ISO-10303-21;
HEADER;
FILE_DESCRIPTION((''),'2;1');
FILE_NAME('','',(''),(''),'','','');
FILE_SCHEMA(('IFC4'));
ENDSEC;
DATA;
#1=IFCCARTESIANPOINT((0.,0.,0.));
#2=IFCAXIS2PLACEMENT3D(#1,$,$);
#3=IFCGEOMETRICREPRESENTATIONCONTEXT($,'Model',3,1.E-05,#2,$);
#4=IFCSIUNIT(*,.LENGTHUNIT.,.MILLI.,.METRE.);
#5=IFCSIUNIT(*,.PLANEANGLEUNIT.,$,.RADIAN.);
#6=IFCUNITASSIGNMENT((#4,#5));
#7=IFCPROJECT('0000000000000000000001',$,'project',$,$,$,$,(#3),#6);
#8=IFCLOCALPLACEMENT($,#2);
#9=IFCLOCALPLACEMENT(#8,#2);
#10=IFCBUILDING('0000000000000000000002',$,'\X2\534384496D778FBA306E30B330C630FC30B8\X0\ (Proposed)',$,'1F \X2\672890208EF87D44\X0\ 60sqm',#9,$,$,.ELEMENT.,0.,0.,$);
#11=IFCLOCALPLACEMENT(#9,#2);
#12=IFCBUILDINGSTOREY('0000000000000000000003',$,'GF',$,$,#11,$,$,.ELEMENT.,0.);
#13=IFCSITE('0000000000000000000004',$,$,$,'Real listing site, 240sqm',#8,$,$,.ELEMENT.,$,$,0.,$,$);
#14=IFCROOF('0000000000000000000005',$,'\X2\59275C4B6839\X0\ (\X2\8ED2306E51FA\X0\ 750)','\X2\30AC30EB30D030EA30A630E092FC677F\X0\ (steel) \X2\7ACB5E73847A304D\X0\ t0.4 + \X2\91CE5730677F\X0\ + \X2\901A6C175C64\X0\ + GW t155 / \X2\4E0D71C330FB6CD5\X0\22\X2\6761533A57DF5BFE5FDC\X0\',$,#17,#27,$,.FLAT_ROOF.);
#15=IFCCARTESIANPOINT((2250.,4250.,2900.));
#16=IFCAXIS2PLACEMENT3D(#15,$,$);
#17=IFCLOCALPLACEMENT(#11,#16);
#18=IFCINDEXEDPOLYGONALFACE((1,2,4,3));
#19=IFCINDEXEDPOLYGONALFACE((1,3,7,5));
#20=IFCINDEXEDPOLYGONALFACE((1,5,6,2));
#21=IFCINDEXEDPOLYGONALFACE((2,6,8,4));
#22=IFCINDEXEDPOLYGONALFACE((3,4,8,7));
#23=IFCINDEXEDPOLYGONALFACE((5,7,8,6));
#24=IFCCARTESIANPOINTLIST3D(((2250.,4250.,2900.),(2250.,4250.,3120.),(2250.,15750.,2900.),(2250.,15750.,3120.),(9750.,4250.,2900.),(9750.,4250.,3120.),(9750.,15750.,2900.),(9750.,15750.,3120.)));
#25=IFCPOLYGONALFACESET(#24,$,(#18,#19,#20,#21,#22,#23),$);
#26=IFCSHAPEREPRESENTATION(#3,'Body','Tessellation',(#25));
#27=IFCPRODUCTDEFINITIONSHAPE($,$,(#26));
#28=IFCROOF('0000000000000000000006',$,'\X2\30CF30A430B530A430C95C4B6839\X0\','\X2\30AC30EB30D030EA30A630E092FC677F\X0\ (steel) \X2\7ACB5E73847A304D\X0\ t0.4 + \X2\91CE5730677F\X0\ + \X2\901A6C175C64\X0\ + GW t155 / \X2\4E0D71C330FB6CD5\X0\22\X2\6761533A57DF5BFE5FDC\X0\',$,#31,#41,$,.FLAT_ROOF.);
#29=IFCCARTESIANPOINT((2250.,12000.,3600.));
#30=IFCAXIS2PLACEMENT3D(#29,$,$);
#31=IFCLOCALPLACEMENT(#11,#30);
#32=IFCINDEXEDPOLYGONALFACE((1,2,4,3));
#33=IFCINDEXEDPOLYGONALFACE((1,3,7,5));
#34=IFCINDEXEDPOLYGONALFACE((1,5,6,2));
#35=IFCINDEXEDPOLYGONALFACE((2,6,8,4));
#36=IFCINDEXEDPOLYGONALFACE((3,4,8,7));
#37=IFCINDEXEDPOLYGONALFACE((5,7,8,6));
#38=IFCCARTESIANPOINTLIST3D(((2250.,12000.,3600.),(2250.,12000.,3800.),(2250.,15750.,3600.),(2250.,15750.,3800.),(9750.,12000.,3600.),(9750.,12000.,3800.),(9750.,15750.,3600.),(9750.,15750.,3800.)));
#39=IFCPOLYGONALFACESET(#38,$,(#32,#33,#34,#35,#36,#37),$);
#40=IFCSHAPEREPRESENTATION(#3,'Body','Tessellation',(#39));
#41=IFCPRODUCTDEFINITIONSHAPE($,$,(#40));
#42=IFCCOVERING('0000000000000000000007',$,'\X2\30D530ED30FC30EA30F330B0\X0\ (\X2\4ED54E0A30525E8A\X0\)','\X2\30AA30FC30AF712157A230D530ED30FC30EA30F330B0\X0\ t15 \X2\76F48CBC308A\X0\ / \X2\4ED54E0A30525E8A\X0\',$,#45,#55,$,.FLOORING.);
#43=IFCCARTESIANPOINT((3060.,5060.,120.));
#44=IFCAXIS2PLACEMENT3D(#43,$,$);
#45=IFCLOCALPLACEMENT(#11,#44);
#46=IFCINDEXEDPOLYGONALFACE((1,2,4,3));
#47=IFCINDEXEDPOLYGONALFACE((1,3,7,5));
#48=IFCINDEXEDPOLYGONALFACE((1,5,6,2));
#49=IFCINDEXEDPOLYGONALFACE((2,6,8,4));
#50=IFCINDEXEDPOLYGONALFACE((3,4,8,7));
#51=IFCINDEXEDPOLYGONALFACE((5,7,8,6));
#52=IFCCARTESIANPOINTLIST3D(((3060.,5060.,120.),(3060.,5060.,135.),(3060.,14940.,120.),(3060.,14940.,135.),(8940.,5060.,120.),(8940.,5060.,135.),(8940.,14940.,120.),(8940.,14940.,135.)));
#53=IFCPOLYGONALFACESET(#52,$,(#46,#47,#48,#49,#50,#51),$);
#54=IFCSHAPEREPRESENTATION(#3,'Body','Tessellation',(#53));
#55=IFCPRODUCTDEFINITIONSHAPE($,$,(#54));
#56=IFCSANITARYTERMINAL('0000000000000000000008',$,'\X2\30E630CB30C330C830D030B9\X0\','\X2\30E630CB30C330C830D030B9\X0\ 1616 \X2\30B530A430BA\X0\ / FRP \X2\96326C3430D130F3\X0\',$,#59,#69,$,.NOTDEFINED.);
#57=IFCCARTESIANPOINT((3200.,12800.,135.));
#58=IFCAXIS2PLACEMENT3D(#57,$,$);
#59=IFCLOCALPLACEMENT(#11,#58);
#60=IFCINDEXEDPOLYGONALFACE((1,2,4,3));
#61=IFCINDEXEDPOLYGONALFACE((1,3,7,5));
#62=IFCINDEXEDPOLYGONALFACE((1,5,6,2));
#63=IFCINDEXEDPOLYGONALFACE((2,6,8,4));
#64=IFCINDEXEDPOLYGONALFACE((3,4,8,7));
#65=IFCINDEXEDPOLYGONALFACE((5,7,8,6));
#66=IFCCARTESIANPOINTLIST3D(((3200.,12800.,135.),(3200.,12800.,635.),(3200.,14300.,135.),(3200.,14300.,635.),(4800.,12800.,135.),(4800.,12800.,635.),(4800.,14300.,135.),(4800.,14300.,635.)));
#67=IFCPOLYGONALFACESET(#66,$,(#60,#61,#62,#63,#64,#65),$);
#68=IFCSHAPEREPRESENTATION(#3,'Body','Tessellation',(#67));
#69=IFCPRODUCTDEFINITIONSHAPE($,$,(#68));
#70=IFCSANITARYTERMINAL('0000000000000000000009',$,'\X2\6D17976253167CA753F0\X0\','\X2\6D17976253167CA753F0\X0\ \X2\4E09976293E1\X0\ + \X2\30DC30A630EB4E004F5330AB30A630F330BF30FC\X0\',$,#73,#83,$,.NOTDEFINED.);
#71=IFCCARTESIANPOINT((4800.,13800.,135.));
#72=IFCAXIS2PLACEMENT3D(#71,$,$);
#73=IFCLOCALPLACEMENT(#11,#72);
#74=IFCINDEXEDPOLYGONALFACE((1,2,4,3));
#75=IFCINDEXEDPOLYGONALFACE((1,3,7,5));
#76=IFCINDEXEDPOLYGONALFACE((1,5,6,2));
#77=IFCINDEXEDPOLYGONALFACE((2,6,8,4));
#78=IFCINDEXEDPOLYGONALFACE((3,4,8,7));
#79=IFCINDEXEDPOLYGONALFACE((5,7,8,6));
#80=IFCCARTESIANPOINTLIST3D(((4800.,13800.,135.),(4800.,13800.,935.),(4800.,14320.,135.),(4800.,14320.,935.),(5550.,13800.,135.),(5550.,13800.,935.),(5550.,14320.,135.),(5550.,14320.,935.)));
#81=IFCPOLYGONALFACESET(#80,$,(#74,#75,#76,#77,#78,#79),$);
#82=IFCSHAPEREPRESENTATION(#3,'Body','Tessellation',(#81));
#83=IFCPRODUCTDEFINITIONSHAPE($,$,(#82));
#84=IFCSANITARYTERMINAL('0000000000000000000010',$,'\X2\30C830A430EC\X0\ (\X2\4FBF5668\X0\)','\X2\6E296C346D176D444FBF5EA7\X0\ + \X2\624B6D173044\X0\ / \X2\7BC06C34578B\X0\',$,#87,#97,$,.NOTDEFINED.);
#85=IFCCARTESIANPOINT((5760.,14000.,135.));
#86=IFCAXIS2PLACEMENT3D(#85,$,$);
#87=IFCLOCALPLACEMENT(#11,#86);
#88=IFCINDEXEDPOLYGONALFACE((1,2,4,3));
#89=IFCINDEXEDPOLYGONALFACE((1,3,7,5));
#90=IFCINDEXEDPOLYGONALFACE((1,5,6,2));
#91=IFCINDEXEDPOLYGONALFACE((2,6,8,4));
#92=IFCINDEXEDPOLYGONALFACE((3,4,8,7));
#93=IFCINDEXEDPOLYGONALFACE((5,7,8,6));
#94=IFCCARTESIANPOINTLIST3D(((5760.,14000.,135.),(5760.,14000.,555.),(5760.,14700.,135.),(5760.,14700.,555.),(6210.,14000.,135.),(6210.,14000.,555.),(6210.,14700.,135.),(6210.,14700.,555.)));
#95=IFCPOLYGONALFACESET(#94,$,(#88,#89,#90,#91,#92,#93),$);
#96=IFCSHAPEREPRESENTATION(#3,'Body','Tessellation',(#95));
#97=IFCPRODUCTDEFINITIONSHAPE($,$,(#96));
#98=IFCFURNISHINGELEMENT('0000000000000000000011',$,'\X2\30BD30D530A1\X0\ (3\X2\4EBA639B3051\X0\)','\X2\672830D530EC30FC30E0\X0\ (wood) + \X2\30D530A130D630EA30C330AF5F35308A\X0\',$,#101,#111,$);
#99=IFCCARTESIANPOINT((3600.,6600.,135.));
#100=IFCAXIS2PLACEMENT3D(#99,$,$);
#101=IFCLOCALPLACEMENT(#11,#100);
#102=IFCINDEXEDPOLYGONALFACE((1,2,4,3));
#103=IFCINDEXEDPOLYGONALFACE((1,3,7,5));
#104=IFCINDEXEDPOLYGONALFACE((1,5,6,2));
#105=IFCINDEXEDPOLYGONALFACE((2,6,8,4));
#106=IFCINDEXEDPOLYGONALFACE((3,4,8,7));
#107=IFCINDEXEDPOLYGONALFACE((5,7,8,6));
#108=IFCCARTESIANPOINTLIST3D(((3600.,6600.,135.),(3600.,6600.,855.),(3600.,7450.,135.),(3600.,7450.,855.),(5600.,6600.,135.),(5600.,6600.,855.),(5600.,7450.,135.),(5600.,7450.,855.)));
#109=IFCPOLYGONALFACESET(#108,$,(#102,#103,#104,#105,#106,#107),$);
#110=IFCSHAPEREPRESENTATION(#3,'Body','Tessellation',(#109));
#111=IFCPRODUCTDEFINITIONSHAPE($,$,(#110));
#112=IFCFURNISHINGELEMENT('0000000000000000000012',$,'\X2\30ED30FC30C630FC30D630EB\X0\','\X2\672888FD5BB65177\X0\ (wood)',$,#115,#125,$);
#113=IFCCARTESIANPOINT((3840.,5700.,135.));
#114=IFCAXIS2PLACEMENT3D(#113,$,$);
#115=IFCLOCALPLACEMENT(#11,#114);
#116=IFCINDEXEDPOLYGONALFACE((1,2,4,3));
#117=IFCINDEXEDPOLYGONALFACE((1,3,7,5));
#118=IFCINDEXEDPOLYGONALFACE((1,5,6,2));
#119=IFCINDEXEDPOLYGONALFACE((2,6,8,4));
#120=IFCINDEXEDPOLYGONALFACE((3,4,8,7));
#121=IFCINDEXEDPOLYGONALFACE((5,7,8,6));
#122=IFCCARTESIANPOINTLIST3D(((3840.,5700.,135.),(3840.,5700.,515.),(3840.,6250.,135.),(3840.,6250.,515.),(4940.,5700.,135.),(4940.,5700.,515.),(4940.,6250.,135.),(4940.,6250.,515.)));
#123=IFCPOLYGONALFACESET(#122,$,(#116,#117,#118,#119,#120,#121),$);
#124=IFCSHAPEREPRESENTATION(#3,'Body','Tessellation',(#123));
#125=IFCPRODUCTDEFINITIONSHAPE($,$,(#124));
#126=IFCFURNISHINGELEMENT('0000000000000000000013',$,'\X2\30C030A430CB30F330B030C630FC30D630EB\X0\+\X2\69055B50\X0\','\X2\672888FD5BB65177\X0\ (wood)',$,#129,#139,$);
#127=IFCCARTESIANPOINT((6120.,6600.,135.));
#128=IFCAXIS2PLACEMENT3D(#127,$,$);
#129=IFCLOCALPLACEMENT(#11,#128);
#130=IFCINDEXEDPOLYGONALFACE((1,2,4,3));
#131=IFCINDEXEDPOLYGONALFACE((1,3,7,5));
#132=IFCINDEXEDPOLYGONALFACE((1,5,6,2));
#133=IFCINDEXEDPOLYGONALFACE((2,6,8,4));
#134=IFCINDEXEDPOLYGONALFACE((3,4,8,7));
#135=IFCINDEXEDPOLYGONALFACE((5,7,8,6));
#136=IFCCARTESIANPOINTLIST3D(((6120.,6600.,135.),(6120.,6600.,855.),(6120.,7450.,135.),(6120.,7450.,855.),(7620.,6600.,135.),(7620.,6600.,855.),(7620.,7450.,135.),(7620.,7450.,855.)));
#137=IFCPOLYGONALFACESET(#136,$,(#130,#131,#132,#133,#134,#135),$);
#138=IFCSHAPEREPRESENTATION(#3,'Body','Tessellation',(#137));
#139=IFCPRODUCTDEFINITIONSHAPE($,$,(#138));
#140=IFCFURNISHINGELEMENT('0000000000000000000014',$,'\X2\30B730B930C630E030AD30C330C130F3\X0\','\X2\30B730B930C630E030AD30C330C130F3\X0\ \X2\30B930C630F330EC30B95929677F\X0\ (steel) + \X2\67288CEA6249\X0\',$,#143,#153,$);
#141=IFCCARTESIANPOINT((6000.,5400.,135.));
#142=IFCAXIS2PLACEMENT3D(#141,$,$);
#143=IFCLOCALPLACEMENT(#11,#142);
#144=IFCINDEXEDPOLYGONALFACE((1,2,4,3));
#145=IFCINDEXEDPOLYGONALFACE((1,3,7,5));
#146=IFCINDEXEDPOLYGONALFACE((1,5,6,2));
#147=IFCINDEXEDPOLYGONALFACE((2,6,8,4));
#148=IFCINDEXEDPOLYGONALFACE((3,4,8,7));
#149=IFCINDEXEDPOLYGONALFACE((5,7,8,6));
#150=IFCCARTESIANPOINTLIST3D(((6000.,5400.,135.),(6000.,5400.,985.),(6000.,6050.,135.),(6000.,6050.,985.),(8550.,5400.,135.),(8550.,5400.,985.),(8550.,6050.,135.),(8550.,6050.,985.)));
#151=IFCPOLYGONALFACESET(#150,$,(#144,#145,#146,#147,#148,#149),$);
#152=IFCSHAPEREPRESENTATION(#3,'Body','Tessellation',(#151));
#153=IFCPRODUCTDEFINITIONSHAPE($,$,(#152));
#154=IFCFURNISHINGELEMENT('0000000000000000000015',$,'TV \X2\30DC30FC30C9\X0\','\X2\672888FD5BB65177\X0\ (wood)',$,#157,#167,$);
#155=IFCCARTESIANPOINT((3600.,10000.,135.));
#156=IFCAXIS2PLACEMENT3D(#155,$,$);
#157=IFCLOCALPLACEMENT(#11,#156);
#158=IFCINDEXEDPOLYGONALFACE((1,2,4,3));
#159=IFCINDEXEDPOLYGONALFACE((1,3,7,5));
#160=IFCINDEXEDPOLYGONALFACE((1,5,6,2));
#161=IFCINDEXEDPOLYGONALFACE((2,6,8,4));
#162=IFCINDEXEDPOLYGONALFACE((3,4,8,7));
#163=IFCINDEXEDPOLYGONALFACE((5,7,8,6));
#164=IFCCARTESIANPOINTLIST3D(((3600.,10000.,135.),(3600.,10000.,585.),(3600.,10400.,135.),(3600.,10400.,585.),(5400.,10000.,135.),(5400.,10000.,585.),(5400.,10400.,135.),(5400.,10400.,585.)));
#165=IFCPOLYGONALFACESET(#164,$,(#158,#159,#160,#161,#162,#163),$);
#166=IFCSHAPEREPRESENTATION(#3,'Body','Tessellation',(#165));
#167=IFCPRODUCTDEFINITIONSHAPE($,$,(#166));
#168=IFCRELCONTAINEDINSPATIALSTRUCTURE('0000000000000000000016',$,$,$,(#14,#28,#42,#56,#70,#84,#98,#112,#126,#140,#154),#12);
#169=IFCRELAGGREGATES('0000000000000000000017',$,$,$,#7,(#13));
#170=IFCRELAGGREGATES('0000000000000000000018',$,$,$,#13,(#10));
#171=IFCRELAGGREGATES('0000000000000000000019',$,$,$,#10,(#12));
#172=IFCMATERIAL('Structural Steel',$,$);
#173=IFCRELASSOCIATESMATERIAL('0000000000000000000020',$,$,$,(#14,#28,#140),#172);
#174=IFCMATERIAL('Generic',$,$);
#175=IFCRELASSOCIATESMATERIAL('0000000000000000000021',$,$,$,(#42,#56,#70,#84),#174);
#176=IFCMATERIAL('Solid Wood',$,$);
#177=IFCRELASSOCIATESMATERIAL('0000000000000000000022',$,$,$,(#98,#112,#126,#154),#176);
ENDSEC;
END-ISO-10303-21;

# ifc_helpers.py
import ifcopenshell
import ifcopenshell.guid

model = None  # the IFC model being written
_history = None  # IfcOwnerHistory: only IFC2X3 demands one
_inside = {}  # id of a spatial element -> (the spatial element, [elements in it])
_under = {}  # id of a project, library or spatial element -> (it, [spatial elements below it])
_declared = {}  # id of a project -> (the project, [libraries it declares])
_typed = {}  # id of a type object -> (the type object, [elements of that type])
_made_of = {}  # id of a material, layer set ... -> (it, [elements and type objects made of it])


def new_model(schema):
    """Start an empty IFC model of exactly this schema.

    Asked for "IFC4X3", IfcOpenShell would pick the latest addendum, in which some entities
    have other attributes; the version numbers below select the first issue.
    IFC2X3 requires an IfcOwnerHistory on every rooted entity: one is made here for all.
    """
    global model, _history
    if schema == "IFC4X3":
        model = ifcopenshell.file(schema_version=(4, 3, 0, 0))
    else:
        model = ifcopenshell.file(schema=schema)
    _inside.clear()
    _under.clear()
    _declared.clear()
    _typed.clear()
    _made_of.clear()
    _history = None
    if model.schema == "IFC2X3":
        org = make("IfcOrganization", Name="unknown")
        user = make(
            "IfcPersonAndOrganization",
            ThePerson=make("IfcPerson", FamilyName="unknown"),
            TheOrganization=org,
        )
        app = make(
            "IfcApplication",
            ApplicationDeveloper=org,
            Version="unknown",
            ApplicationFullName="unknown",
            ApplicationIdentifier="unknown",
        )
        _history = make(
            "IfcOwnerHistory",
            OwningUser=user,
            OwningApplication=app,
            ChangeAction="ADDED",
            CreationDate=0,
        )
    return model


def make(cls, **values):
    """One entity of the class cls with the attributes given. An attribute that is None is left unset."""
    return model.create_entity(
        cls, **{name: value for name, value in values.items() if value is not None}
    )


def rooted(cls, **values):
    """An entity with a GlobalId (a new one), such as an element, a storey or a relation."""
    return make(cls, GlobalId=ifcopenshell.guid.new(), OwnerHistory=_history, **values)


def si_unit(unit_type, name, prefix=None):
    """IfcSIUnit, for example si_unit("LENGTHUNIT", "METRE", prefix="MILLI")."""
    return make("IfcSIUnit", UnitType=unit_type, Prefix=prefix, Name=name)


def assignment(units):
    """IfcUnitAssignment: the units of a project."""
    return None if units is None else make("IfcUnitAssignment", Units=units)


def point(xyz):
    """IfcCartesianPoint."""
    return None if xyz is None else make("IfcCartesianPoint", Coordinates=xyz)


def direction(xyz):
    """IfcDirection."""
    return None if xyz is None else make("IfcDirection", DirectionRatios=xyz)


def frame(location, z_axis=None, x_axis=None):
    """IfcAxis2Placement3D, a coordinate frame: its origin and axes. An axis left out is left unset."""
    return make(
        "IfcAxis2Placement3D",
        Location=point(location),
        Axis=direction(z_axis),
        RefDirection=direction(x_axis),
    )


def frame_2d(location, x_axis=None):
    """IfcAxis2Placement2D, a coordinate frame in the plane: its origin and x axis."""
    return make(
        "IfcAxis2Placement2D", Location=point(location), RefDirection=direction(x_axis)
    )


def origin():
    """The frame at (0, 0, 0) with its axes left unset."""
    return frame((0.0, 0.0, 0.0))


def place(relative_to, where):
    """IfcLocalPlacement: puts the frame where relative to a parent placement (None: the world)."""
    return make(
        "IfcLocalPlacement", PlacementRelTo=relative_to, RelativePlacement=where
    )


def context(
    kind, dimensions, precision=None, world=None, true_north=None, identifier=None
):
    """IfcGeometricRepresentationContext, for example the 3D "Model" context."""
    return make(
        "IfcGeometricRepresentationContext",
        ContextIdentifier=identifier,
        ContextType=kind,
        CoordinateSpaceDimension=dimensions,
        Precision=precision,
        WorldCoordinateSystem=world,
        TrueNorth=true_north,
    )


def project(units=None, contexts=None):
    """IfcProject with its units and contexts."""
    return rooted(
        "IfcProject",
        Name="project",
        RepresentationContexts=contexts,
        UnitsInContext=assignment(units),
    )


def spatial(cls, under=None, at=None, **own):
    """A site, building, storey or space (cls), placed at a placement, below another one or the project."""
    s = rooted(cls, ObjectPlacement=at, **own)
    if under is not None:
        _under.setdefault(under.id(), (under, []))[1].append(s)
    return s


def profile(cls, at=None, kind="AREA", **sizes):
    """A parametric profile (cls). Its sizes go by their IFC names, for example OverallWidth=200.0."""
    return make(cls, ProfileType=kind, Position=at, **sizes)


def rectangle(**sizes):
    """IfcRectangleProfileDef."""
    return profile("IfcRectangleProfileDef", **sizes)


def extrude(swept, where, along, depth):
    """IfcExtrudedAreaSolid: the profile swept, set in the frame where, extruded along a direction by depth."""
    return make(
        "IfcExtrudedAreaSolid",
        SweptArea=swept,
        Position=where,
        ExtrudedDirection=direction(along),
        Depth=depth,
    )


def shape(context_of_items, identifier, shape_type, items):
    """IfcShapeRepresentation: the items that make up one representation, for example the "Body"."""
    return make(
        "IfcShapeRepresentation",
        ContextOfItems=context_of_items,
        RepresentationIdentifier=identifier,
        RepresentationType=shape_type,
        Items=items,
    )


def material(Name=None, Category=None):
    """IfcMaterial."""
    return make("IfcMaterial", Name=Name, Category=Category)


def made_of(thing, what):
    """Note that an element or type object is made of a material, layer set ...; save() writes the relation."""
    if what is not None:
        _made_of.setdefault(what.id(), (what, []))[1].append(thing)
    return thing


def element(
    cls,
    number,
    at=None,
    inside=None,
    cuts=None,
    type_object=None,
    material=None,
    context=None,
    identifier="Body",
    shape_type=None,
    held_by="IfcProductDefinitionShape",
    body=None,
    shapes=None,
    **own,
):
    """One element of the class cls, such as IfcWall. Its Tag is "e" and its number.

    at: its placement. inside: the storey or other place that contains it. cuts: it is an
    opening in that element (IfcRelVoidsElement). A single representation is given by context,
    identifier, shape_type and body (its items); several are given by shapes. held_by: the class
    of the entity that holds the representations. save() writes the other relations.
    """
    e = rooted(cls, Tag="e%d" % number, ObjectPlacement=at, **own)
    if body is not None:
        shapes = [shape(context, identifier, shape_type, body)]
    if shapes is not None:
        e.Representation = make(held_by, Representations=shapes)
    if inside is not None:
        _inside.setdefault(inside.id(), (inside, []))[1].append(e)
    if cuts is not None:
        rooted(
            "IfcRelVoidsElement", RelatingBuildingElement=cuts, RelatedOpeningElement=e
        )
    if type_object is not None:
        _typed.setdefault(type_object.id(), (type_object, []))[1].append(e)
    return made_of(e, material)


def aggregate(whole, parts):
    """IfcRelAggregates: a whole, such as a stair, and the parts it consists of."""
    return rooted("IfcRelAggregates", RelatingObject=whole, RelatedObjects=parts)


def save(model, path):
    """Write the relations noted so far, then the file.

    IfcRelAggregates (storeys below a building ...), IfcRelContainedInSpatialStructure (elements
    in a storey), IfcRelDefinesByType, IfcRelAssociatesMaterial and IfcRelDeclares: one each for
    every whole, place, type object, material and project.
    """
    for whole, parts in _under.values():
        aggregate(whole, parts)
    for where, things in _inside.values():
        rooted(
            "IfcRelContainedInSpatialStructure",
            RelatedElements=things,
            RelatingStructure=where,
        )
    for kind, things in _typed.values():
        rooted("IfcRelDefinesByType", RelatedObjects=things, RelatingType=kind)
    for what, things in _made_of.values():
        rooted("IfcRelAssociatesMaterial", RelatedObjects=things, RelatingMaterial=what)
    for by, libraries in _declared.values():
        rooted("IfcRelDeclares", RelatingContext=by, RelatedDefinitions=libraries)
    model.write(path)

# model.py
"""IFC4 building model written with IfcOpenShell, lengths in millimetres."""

from ifc_helpers import new_model, si_unit, frame, frame_2d, origin, place, context, project, spatial, rectangle, extrude, material, element, save


model = new_model("IFC4")

# Units and contexts
model_context = context("Model", 3, precision=1e-05, world=origin())
ifc_project = project(units=[si_unit("LENGTHUNIT", "METRE", prefix="MILLI"), si_unit("PLANEANGLEUNIT", "RADIAN")], contexts=[model_context])

# Site, building, storey
site_placement = place(None, origin())
site = spatial("IfcSite", under=ifc_project, at=site_placement, ObjectType="Real listing site, 240sqm", CompositionType="ELEMENT", RefElevation=0.0)
building_placement = place(site_placement, origin())
building = spatial("IfcBuilding", under=site, at=building_placement, Name="千葉海辺のコテージ (Proposed)", ObjectType="1F 木造軸組 60sqm", CompositionType="ELEMENT", ElevationOfRefHeight=0.0, ElevationOfTerrain=0.0)
storey_placement = place(building_placement, origin())
storey = spatial("IfcBuildingStorey", under=building, at=storey_placement, Name="GF", CompositionType="ELEMENT", Elevation=0.0)

# Shared definitions
ifc_material_1 = material(Name="Solid Wood")

# Roofs
ifc_material_2 = material(Name="Structural Steel")
roof_1_placement = place(storey_placement, frame((2250.0, 4250.0, 2900.0)))
element("IfcRoof", 1, at=roof_1_placement, inside=storey, material=ifc_material_2, Name="大屋根 (軒の出 750)", Description="ガルバリウム鋼板 (steel) 立平葺き t0.4 + 野地板 + 通気層 + GW t155 / 不燃・法22条区域対応", PredefinedType="FLAT_ROOF", context=model_context, shape_type="SweptSolid", body=[
    extrude(rectangle(XDim=7500.0, YDim=11500.0, at=frame_2d((3750.0, 5750.0))), frame((2250.0, 4250.0, 2900.0)), (0.0, 0.0, 1.0), 220.0),
])
roof_2_placement = place(storey_placement, frame((2250.0, 12000.0, 3600.0)))
element("IfcRoof", 2, at=roof_2_placement, inside=storey, material=ifc_material_2, Name="ハイサイド屋根", Description="ガルバリウム鋼板 (steel) 立平葺き t0.4 + 野地板 + 通気層 + GW t155 / 不燃・法22条区域対応", PredefinedType="FLAT_ROOF", context=model_context, shape_type="SweptSolid", body=[
    extrude(rectangle(XDim=7500.0, YDim=3750.0, at=frame_2d((3750.0, 1875.0))), frame((2250.0, 12000.0, 3600.0)), (0.0, 0.0, 1.0), 200.0),
])

# Covering
ifc_material_3 = material(Name="Generic")
covering_placement = place(storey_placement, frame((3060.0, 5060.0, 120.0)))
element("IfcCovering", 3, at=covering_placement, inside=storey, material=ifc_material_3, Name="フローリング (仕上げ床)", Description="オーク無垢フローリング t15 直貼り / 仕上げ床", PredefinedType="FLOORING", context=model_context, shape_type="SweptSolid", body=[
    extrude(rectangle(XDim=5880.0, YDim=9880.0, at=frame_2d((2940.0, 4940.0))), frame((3060.0, 5060.0, 120.0)), (0.0, 0.0, 1.0), 15.0),
])

# Sanitary terminals
sanitary_terminal_1_placement = place(storey_placement, frame((3200.0, 12800.0, 135.0)))
element("IfcSanitaryTerminal", 4, at=sanitary_terminal_1_placement, inside=storey, material=ifc_material_3, Name="ユニットバス", Description="ユニットバス 1616 サイズ / FRP 防水パン", PredefinedType="NOTDEFINED", context=model_context, shape_type="SweptSolid", body=[
    extrude(rectangle(XDim=1600.0, YDim=1500.0, at=frame_2d((800.0, 750.0))), frame((3200.0, 12800.0, 135.0)), (0.0, 0.0, 1.0), 500.0),
])
sanitary_terminal_2_placement = place(storey_placement, frame((4800.0, 13800.0, 135.0)))
element("IfcSanitaryTerminal", 5, at=sanitary_terminal_2_placement, inside=storey, material=ifc_material_3, Name="洗面化粧台", Description="洗面化粧台 三面鏡 + ボウル一体カウンター", PredefinedType="NOTDEFINED", context=model_context, shape_type="SweptSolid", body=[
    extrude(rectangle(XDim=750.0, YDim=520.0, at=frame_2d((375.0, 260.0))), frame((4800.0, 13800.0, 135.0)), (0.0, 0.0, 1.0), 800.0),
])
sanitary_terminal_3_placement = place(storey_placement, frame((5760.0, 14000.0, 135.0)))
element("IfcSanitaryTerminal", 6, at=sanitary_terminal_3_placement, inside=storey, material=ifc_material_3, Name="トイレ (便器)", Description="温水洗浄便座 + 手洗い / 節水型", PredefinedType="NOTDEFINED", context=model_context, shape_type="SweptSolid", body=[
    extrude(rectangle(XDim=450.0, YDim=700.0, at=frame_2d((225.0, 350.0))), frame((5760.0, 14000.0, 135.0)), (0.0, 0.0, 1.0), 420.0),
])

# Furnishing elements
furnishing_1_placement = place(storey_placement, frame((3600.0, 6600.0, 135.0)))
element("IfcFurnishingElement", 7, at=furnishing_1_placement, inside=storey, material=ifc_material_1, Name="ソファ (3人掛け)", Description="木フレーム (wood) + ファブリック張り", context=model_context, shape_type="SweptSolid", body=[
    extrude(rectangle(XDim=2000.0, YDim=850.0, at=frame_2d((1000.0, 425.0))), frame((3600.0, 6600.0, 135.0)), (0.0, 0.0, 1.0), 720.0),
])
furnishing_2_placement = place(storey_placement, frame((3840.0, 5700.0, 135.0)))
element("IfcFurnishingElement", 8, at=furnishing_2_placement, inside=storey, material=ifc_material_1, Name="ローテーブル", Description="木製家具 (wood)", context=model_context, shape_type="SweptSolid", body=[
    extrude(rectangle(XDim=1100.0, YDim=550.0, at=frame_2d((550.0, 275.0))), frame((3840.0, 5700.0, 135.0)), (0.0, 0.0, 1.0), 380.0),
])
furnishing_3_placement = place(storey_placement, frame((6120.0, 6600.0, 135.0)))
element("IfcFurnishingElement", 9, at=furnishing_3_placement, inside=storey, material=ifc_material_1, Name="ダイニングテーブル+椅子", Description="木製家具 (wood)", context=model_context, shape_type="SweptSolid", body=[
    extrude(rectangle(XDim=1500.0, YDim=850.0, at=frame_2d((750.0, 425.0))), frame((6120.0, 6600.0, 135.0)), (0.0, 0.0, 1.0), 720.0),
])
furnishing_4_placement = place(storey_placement, frame((6000.0, 5400.0, 135.0)))
element("IfcFurnishingElement", 10, at=furnishing_4_placement, inside=storey, material=ifc_material_2, Name="システムキッチン", Description="システムキッチン ステンレス天板 (steel) + 木質扉", context=model_context, shape_type="SweptSolid", body=[
    extrude(rectangle(XDim=2550.0, YDim=650.0, at=frame_2d((1275.0, 325.0))), frame((6000.0, 5400.0, 135.0)), (0.0, 0.0, 1.0), 850.0),
])
furnishing_5_placement = place(storey_placement, frame((3600.0, 10000.0, 135.0)))
element("IfcFurnishingElement", 11, at=furnishing_5_placement, inside=storey, material=ifc_material_1, Name="TV ボード", Description="木製家具 (wood)", context=model_context, shape_type="SweptSolid", body=[
    extrude(rectangle(XDim=1800.0, YDim=400.0, at=frame_2d((900.0, 200.0))), frame((3600.0, 10000.0, 135.0)), (0.0, 0.0, 1.0), 450.0),
])

save(model, "model.ifc")
